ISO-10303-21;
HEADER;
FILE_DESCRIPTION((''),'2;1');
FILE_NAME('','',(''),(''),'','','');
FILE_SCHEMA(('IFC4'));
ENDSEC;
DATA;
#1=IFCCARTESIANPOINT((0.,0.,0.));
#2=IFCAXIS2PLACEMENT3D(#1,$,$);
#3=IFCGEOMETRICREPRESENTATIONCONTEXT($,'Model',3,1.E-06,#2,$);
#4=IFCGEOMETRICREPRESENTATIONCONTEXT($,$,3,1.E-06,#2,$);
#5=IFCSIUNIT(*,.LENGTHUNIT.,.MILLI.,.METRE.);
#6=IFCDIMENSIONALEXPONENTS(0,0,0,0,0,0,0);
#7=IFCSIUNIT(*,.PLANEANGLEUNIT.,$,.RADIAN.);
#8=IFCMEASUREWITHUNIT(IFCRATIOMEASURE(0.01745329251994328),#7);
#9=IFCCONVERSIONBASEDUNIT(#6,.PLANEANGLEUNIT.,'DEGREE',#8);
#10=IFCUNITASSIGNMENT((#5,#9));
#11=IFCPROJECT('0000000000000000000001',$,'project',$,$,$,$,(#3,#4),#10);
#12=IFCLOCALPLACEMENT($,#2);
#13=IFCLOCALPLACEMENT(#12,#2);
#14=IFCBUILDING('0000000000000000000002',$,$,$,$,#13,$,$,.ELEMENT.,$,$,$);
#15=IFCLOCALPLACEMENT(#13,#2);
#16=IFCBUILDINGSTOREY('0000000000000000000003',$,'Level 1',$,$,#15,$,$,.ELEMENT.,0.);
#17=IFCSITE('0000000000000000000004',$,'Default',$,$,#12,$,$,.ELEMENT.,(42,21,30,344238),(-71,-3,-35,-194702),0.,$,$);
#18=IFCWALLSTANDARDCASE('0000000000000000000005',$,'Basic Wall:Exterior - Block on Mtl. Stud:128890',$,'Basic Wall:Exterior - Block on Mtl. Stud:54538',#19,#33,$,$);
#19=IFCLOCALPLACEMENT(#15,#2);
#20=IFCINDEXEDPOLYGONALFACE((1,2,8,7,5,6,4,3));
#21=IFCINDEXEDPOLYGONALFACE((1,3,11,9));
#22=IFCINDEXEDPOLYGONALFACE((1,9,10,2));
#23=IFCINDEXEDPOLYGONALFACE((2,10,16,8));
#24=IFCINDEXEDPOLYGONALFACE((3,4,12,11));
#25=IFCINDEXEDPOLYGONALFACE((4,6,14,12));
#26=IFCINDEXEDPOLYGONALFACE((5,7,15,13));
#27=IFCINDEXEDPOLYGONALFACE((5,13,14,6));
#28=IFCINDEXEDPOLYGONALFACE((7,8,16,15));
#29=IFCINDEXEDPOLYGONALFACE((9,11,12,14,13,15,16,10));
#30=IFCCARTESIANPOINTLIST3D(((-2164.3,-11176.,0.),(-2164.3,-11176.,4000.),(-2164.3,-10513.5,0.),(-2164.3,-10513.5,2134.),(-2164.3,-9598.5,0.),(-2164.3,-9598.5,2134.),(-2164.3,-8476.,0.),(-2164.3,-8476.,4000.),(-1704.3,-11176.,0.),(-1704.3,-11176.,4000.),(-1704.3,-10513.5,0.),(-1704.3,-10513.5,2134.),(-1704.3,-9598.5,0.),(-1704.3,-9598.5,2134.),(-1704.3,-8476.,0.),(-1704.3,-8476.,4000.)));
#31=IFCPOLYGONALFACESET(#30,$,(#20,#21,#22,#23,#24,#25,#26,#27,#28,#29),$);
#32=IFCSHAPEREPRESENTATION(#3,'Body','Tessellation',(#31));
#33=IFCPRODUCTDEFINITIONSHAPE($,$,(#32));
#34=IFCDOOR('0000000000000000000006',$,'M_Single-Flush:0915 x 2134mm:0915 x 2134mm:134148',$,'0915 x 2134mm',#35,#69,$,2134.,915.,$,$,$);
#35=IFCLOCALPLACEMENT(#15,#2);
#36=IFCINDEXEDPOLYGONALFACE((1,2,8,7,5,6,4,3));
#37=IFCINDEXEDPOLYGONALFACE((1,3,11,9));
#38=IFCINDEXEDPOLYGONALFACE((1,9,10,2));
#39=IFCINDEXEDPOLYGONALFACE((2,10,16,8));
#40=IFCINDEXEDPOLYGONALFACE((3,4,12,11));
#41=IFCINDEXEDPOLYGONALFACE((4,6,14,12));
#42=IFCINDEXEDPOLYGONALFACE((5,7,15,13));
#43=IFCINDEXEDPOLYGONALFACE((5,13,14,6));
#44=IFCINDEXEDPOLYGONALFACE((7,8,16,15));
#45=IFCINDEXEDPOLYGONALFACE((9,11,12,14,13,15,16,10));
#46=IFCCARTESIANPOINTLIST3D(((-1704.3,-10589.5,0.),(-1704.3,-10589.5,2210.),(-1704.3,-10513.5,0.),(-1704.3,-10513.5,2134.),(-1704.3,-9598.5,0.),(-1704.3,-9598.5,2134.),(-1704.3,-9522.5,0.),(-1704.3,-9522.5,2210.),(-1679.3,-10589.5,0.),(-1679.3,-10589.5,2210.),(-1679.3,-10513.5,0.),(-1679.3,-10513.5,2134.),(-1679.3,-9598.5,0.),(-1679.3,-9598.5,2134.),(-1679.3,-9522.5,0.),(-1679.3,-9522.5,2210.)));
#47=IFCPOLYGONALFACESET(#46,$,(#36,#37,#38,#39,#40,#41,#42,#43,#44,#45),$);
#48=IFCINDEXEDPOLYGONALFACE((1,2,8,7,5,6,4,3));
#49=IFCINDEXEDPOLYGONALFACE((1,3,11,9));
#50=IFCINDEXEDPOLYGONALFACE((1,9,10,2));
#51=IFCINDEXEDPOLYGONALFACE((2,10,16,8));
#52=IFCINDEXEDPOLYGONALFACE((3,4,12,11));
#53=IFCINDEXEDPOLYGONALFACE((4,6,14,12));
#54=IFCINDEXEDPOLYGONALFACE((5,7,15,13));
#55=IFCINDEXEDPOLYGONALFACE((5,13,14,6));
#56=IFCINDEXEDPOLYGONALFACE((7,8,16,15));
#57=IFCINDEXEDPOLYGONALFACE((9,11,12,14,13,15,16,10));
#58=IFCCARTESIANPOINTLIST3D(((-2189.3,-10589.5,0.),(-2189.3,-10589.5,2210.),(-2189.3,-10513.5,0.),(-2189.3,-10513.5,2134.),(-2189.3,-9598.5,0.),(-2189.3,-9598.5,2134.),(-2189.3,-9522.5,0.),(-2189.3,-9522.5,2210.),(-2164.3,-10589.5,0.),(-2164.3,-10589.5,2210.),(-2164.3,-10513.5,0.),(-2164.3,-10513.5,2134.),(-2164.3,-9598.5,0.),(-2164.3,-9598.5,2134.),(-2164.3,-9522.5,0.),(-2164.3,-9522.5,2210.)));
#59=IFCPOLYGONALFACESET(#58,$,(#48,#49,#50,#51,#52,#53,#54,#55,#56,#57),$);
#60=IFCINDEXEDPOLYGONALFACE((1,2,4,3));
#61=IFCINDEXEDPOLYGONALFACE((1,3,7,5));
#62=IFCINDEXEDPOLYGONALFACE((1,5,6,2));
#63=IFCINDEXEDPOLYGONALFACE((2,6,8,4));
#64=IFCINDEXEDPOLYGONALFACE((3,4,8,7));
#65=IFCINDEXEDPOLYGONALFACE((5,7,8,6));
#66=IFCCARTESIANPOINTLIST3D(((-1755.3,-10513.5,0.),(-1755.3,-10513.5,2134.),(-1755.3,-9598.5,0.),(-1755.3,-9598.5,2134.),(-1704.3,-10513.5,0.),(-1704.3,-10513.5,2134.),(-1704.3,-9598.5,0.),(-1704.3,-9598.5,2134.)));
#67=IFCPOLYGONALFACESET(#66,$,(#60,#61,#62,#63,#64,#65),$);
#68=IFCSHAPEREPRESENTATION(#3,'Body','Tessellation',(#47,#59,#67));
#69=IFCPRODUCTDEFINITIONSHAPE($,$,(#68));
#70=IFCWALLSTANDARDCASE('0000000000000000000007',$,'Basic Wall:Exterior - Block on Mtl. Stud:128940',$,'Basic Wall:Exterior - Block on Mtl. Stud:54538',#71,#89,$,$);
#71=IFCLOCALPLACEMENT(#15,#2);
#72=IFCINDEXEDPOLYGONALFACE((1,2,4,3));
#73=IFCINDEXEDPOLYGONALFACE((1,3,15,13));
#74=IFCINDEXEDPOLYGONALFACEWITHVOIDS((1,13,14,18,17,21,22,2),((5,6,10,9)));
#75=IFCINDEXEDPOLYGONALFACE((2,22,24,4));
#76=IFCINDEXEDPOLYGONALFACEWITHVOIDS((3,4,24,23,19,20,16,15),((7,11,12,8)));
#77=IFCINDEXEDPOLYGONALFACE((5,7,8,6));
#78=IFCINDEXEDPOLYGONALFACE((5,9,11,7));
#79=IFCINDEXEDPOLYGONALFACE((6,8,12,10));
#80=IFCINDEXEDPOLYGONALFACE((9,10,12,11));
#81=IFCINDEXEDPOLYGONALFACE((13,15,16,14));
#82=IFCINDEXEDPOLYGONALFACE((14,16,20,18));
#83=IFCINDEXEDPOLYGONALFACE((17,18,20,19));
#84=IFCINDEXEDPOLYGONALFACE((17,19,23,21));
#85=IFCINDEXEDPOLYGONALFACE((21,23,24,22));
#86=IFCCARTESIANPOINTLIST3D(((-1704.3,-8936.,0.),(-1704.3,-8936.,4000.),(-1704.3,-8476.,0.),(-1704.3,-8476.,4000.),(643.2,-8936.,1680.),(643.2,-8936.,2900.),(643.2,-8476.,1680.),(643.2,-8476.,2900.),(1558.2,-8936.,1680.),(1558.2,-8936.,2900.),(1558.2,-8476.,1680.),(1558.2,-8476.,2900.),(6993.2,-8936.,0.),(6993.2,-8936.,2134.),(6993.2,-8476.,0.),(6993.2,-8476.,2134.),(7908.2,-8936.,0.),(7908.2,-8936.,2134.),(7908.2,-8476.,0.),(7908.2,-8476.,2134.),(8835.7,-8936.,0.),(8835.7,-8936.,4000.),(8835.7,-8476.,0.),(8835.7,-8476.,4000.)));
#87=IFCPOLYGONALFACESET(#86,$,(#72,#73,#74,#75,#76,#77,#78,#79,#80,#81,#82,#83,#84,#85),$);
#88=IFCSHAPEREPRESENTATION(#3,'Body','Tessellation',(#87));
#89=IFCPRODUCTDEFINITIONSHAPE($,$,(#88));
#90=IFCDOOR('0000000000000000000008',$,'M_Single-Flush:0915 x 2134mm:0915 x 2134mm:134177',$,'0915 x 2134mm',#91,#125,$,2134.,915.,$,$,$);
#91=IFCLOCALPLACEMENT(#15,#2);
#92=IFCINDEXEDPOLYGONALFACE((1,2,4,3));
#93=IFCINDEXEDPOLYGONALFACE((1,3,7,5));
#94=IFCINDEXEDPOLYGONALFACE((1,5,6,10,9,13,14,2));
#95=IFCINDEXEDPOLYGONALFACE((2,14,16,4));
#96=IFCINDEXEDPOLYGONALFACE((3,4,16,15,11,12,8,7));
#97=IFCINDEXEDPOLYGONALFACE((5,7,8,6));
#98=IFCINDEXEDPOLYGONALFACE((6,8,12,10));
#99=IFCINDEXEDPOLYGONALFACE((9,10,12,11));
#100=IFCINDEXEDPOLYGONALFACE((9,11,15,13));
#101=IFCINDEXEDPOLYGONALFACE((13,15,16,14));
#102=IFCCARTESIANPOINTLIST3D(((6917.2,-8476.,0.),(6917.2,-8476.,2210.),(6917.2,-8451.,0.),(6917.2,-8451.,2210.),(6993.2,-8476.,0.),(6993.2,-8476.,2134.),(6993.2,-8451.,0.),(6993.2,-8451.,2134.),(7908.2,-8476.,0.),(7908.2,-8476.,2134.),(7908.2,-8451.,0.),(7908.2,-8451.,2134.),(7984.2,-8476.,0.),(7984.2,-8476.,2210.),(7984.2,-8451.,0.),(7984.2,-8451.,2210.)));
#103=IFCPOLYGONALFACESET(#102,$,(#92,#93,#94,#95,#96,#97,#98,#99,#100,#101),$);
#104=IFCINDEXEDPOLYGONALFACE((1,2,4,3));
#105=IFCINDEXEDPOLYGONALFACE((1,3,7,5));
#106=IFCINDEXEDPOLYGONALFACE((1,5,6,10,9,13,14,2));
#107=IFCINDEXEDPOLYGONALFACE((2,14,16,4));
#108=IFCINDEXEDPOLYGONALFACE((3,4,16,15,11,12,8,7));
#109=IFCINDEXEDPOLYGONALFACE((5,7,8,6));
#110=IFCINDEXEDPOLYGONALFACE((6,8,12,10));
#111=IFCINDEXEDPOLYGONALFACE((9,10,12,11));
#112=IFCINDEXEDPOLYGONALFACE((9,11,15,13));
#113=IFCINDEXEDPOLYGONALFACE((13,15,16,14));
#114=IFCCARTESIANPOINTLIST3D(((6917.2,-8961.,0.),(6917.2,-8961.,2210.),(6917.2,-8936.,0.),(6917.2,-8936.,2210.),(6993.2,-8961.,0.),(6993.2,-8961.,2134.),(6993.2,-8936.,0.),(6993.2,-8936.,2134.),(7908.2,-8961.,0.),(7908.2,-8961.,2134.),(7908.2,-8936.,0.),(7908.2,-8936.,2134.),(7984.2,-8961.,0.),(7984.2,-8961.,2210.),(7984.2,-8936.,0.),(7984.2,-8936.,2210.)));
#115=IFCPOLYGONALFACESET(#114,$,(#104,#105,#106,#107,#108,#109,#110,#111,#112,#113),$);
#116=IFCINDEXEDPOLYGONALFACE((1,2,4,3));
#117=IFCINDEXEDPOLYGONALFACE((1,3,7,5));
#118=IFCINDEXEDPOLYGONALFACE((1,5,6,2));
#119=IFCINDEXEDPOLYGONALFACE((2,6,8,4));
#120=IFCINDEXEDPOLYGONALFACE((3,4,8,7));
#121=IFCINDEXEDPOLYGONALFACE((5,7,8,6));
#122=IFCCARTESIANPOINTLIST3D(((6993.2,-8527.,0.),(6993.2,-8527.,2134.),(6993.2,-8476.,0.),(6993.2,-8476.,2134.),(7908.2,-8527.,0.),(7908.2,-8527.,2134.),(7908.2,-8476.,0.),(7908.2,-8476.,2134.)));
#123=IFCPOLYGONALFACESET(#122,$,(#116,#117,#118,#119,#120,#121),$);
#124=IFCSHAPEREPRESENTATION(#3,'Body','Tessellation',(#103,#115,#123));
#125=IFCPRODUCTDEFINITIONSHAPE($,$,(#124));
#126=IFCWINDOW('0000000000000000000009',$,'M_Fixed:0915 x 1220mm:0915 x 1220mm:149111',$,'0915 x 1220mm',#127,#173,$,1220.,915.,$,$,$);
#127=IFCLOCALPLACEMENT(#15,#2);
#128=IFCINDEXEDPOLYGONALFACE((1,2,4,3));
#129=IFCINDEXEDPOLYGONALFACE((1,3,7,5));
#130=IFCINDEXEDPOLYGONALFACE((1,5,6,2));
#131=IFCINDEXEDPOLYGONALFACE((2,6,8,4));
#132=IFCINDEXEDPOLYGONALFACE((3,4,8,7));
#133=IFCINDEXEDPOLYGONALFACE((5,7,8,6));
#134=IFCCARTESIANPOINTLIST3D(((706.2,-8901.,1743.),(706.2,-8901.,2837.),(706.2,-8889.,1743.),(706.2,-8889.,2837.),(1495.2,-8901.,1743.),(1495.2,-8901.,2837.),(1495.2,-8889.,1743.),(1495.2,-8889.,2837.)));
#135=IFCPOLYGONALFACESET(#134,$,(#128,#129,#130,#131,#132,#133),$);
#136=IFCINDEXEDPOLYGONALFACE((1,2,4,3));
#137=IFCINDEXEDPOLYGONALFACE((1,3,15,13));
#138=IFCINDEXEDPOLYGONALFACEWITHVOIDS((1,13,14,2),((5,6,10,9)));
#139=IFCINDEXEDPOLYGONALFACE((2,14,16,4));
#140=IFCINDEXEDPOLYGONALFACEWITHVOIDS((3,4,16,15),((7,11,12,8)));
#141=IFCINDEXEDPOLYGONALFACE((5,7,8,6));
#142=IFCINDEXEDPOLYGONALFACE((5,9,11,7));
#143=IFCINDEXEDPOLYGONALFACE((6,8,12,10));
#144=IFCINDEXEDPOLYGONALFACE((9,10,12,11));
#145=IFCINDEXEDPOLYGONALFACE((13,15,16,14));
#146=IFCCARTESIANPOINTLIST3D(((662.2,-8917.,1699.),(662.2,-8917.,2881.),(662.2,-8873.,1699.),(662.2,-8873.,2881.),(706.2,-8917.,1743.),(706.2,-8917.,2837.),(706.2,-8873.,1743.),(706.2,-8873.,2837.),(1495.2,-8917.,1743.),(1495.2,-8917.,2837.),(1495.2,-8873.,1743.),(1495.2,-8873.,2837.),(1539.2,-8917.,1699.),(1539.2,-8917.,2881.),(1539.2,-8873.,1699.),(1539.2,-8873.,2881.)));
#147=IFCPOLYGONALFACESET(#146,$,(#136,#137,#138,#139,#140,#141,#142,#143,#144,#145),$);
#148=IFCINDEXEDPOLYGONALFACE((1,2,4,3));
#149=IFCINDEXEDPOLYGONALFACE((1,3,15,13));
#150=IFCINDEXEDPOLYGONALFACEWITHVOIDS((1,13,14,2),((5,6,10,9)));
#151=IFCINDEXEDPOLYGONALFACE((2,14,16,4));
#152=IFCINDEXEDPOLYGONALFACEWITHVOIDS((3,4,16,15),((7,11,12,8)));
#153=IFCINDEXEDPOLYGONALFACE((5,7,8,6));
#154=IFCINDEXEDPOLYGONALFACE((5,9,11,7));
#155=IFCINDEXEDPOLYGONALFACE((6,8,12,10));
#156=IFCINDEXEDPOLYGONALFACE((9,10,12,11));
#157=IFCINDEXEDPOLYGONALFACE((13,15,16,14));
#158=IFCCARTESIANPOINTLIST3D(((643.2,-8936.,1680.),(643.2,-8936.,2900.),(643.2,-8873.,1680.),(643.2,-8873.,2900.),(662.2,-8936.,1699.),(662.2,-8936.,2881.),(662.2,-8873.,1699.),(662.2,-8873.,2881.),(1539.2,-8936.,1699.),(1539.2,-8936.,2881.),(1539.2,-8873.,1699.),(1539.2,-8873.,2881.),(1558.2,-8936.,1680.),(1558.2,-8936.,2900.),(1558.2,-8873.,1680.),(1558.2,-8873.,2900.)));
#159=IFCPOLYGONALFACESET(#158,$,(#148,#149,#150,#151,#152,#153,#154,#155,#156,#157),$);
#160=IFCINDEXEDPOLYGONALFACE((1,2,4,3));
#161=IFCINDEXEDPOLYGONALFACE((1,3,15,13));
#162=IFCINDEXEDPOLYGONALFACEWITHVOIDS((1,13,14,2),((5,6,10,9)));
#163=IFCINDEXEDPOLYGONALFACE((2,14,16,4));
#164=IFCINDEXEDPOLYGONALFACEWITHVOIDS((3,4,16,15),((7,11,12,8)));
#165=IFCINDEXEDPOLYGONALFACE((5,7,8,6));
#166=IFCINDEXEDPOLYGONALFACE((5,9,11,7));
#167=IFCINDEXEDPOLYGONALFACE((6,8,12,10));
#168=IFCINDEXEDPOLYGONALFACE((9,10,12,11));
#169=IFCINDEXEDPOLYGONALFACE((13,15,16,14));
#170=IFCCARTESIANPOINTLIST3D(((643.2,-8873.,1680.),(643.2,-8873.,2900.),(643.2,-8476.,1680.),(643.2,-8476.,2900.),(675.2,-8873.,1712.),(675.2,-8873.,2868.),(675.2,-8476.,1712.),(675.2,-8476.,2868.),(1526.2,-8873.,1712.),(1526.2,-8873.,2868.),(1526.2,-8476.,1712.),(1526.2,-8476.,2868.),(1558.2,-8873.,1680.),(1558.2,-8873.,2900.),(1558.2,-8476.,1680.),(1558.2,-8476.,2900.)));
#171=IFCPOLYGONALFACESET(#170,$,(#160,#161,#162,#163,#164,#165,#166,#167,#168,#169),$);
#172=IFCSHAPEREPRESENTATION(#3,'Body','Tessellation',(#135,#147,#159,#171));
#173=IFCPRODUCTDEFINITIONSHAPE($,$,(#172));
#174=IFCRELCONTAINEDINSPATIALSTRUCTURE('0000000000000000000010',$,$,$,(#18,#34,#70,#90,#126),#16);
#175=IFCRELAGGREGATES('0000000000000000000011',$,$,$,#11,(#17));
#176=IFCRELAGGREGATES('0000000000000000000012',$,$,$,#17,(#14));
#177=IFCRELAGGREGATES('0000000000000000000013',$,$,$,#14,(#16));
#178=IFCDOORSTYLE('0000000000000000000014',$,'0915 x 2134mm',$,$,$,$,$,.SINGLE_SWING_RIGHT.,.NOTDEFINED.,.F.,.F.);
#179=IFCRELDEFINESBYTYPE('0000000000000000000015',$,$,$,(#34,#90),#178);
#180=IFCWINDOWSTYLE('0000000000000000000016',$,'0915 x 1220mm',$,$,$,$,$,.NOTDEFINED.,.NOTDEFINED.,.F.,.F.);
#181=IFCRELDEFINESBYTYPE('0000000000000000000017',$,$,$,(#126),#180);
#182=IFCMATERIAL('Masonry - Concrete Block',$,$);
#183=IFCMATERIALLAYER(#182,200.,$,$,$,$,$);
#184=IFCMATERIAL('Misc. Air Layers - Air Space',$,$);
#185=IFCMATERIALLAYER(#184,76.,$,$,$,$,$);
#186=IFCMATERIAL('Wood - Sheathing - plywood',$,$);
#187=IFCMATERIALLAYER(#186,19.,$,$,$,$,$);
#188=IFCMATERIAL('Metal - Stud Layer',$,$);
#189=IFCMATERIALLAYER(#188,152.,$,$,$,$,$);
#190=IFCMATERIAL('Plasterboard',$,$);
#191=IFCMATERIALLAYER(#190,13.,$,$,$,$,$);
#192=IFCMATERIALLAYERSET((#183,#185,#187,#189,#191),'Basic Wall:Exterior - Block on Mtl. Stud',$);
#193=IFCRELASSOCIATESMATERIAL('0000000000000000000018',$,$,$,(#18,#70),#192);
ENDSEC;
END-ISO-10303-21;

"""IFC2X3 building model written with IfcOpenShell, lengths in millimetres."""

from ifc_helpers import new_model, entity, si_unit, converted_unit, frame, frame_2d, origin, origin_2d_with_axis, place, context, project, spatial, polyline, rectangle, outline, extrude, source, transform, mapped, material, layer, layer_set, layer_usage, type_object, type_shapes, element, fill, save


model = new_model("IFC2X3")

# Units and contexts
model_context = context("Model", 3, precision=1e-06, world=origin())
context_of_model = context(None, 3, precision=1e-06, world=origin())
ifc_project = project(units=[si_unit("LENGTHUNIT", "METRE", prefix="MILLI"), converted_unit("PLANEANGLEUNIT", "DEGREE", entity("IfcRatioMeasure", 0.01745329251994328), si_unit("PLANEANGLEUNIT", "RADIAN"), dimensions=[0, 0, 0, 0, 0, 0, 0])], contexts=[model_context, context_of_model])

# Site, building, storey
site_placement = place(None, origin())
site = spatial("IfcSite", under=ifc_project, at=site_placement, Name="Default", CompositionType="ELEMENT", RefLatitude=(42, 21, 30, 344238), RefLongitude=(-71, -3, -35, -194702), RefElevation=0.0)
building_placement = place(site_placement, origin())
building = spatial("IfcBuilding", under=site, at=building_placement, CompositionType="ELEMENT")
storey_placement = place(building_placement, origin())
storey = spatial("IfcBuildingStorey", under=building, at=storey_placement, Name="Level 1", CompositionType="ELEMENT", Elevation=0.0)

# Shared definitions
ifc_material_1 = material(Name="Masonry - Concrete Block")
ifc_layer_1 = layer(ifc_material_1, 200.0)
ifc_material_2 = material(Name="Misc. Air Layers - Air Space")
ifc_layer_2 = layer(ifc_material_2, 76.0)
ifc_material_3 = material(Name="Wood - Sheathing - plywood")
ifc_layer_3 = layer(ifc_material_3, 19.0)
ifc_material_4 = material(Name="Metal - Stud Layer")
ifc_layer_4 = layer(ifc_material_4, 152.0)
ifc_material_5 = material(Name="Plasterboard")
ifc_layer_5 = layer(ifc_material_5, 13.0)
ifc_layer_set_1 = layer_set([ifc_layer_1, ifc_layer_2, ifc_layer_3, ifc_layer_4, ifc_layer_5], Name="Basic Wall:Exterior - Block on Mtl. Stud")

# Wall, opening, door
ifc_layer_usage_1 = layer_usage(ifc_layer_set_1, "AXIS2", "NEGATIVE", 230.0)
wall_1_placement = place(storey_placement, frame((-1934.3, -11176.0, 0.0), z_axis=(0.0, 0.0, 1.0), x_axis=(0.0, 1.0, 0.0)))
wall_1 = element("IfcWallStandardCase", 1, at=wall_1_placement, inside=storey, material=ifc_layer_usage_1, Name="Basic Wall:Exterior - Block on Mtl. Stud:128890", ObjectType="Basic Wall:Exterior - Block on Mtl. Stud:54538", context=model_context, shape_type="SweptSolid", body=[
    extrude(rectangle(XDim=2700.0, YDim=460.0, at=frame_2d((1350.0, 0.0), x_axis=(-1.0, 0.0))), origin(), (0.0, 0.0, 1.0), 4000.0),
])
opening_1_placement = place(wall_1_placement, frame((1577.5, 230.0, 0.0)))
opening_1 = element("IfcOpeningElement", 2, at=opening_1_placement, cuts=wall_1, ObjectType="Opening", context=model_context, shape_type="SweptSolid", body=[
    extrude(rectangle(XDim=915.0, YDim=2134.0, at=frame_2d((1067.0, 457.5), x_axis=(0.0, 1.0))), frame((0.0, 0.0, 0.0), z_axis=(0.0, -1.0, 0.0), x_axis=(0.0, 0.0, 1.0)), (0.0, 0.0, 1.0), 460.0),
])
door_style_1 = type_object("IfcDoorStyle", Name="0915 x 2134mm", ConstructionType="NOTDEFINED", OperationType="SINGLE_SWING_RIGHT", ParameterTakesPrecedence=False, Sizeable=False)
shared_shape_1 = source(origin(), model_context, "Body", "SweptSolid", [
    extrude(outline(polyline([(-533.5, -1124.0), (533.5, -1124.0), (533.5, 1086.0), (457.5, 1086.0), (457.5, -1048.0), (-457.5, -1048.0), (-457.5, 1086.0), (-533.5, 1086.0), (-533.5, -1124.0)])), frame((457.5, 460.0, 1086.0), z_axis=(0.0, 1.0, 0.0), x_axis=(1.0, 0.0, 0.0)), (0.0, 0.0, 1.0), 25.0),
    extrude(outline(polyline([(-1124.0, -533.5), (1086.0, -533.5), (1086.0, -457.5), (-1048.0, -457.5), (-1048.0, 457.5), (1086.0, 457.5), (1086.0, 533.5), (-1124.0, 533.5), (-1124.0, -533.5)])), frame((457.5, -25.0, 1086.0), z_axis=(0.0, 1.0, 0.0), x_axis=(0.0, 0.0, -1.0)), (0.0, 0.0, 1.0), 25.0),
    extrude(rectangle(XDim=51.0, YDim=915.0, at=origin_2d_with_axis()), frame((457.5, 434.5, 0.0), z_axis=(0.0, 0.0, 1.0), x_axis=(0.0, 1.0, 0.0)), (0.0, 0.0, 1.0), 2134.0),
])
type_shapes(door_style_1, [shared_shape_1])
door_1_placement = place(opening_1_placement, frame((0.0, 0.0, 0.0), z_axis=(0.0, 0.0, 1.0), x_axis=(-1.0, 0.0, 0.0)))
door_1 = element("IfcDoor", 3, at=door_1_placement, inside=storey, type_object=door_style_1, Name="M_Single-Flush:0915 x 2134mm:0915 x 2134mm:134148", ObjectType="0915 x 2134mm", OverallHeight=2134.0, OverallWidth=915.0, context=model_context, shape_type="MappedRepresentation", body=[
    mapped(shared_shape_1, transform((0.0, 0.0, 0.0), scale=1.0)),
])
fill(opening_1, door_1)

# Wall, openings, door, window
ifc_layer_usage_2 = layer_usage(ifc_layer_set_1, "AXIS2", "NEGATIVE", 230.0)
wall_2_placement = place(storey_placement, frame((-1704.3, -8706.0, 0.0)))
wall_2 = element("IfcWallStandardCase", 4, at=wall_2_placement, inside=storey, material=ifc_layer_usage_2, Name="Basic Wall:Exterior - Block on Mtl. Stud:128940", ObjectType="Basic Wall:Exterior - Block on Mtl. Stud:54538", context=model_context, shape_type="SweptSolid", body=[
    extrude(rectangle(XDim=10540.0, YDim=460.0, at=frame_2d((5270.0, 0.0), x_axis=(-1.0, 0.0))), origin(), (0.0, 0.0, 1.0), 4000.0),
])
opening_2_placement = place(wall_2_placement, frame((8697.5, -230.0, 0.0)))
opening_2 = element("IfcOpeningElement", 5, at=opening_2_placement, cuts=wall_2, ObjectType="Opening", context=model_context, shape_type="SweptSolid", body=[
    extrude(rectangle(XDim=915.0, YDim=2134.0, at=frame_2d((1067.0, 457.5), x_axis=(0.0, 1.0))), frame((0.0, 0.0, 0.0), z_axis=(0.0, 1.0, 0.0), x_axis=(0.0, 0.0, 1.0)), (0.0, 0.0, 1.0), 460.0),
])
opening_3_placement = place(wall_2_placement, frame((2347.5, -230.0, 1680.0)))
opening_3 = element("IfcOpeningElement", 6, at=opening_3_placement, cuts=wall_2, ObjectType="Opening", context=model_context, shape_type="SweptSolid", body=[
    extrude(rectangle(XDim=1220.0, YDim=915.0, at=frame_2d((610.0, 457.5), x_axis=(1.0, 0.0))), frame((0.0, 0.0, 0.0), z_axis=(0.0, 1.0, 0.0), x_axis=(0.0, 0.0, 1.0)), (0.0, 0.0, 1.0), 460.0),
])
door_2_placement = place(opening_2_placement, origin())
door_2 = element("IfcDoor", 7, at=door_2_placement, inside=storey, type_object=door_style_1, Name="M_Single-Flush:0915 x 2134mm:0915 x 2134mm:134177", ObjectType="0915 x 2134mm", OverallHeight=2134.0, OverallWidth=915.0, context=model_context, shape_type="MappedRepresentation", body=[
    mapped(shared_shape_1, transform((0.0, 0.0, 0.0), scale=1.0)),
])
fill(opening_2, door_2)
window_style_1 = type_object("IfcWindowStyle", Name="0915 x 1220mm", ConstructionType="NOTDEFINED", OperationType="NOTDEFINED", ParameterTakesPrecedence=False, Sizeable=False)
shared_shape_2 = source(origin(), model_context, "Body", "SweptSolid", [
    extrude(rectangle(XDim=12.0, YDim=789.0, at=origin_2d_with_axis()), frame((457.5, 419.0, 63.0), z_axis=(0.0, 0.0, 1.0), x_axis=(0.0, -1.0, 0.0)), (0.0, 0.0, 1.0), 1094.0),
    extrude(outline(polyline([(-438.5, -591.0), (438.5, -591.0), (438.5, 591.0), (-438.5, 591.0), (-438.5, -591.0)]), holes=[polyline([(-394.5, -547.0), (-394.5, 547.0), (394.5, 547.0), (394.5, -547.0), (-394.5, -547.0)])]), frame((457.5, 397.0, 610.0), z_axis=(0.0, 1.0, 0.0), x_axis=(1.0, 0.0, 0.0)), (0.0, 0.0, 1.0), 44.0),
    extrude(outline(polyline([(-457.5, -610.0), (457.5, -610.0), (457.5, 610.0), (-457.5, 610.0), (-457.5, -610.0)]), holes=[polyline([(-438.5, -591.0), (-438.5, 591.0), (438.5, 591.0), (438.5, -591.0), (-438.5, -591.0)])]), frame((457.5, 397.0, 610.0), z_axis=(0.0, 1.0, 0.0), x_axis=(1.0, 0.0, 0.0)), (0.0, 0.0, 1.0), 63.0),
    extrude(outline(polyline([(-457.5, -610.0), (457.5, -610.0), (457.5, 610.0), (-457.5, 610.0), (-457.5, -610.0)]), holes=[polyline([(-425.5, -578.0), (-425.5, 578.0), (425.5, 578.0), (425.5, -578.0), (-425.5, -578.0)])]), frame((457.5, 0.0, 610.0), z_axis=(0.0, 1.0, 0.0), x_axis=(1.0, 0.0, 0.0)), (0.0, 0.0, 1.0), 397.0),
])
type_shapes(window_style_1, [shared_shape_2])
window_1_placement = place(opening_3_placement, frame((915.0, 460.0, 0.0), z_axis=(0.0, 0.0, 1.0), x_axis=(-1.0, 0.0, 0.0)))
window_1 = element("IfcWindow", 8, at=window_1_placement, inside=storey, type_object=window_style_1, Name="M_Fixed:0915 x 1220mm:0915 x 1220mm:149111", ObjectType="0915 x 1220mm", OverallHeight=1220.0, OverallWidth=915.0, context=model_context, shape_type="MappedRepresentation", body=[
    mapped(shared_shape_2, transform((0.0, 0.0, 0.0), scale=1.0)),
])
fill(opening_3, window_1)

save(model, "model.ifc")
